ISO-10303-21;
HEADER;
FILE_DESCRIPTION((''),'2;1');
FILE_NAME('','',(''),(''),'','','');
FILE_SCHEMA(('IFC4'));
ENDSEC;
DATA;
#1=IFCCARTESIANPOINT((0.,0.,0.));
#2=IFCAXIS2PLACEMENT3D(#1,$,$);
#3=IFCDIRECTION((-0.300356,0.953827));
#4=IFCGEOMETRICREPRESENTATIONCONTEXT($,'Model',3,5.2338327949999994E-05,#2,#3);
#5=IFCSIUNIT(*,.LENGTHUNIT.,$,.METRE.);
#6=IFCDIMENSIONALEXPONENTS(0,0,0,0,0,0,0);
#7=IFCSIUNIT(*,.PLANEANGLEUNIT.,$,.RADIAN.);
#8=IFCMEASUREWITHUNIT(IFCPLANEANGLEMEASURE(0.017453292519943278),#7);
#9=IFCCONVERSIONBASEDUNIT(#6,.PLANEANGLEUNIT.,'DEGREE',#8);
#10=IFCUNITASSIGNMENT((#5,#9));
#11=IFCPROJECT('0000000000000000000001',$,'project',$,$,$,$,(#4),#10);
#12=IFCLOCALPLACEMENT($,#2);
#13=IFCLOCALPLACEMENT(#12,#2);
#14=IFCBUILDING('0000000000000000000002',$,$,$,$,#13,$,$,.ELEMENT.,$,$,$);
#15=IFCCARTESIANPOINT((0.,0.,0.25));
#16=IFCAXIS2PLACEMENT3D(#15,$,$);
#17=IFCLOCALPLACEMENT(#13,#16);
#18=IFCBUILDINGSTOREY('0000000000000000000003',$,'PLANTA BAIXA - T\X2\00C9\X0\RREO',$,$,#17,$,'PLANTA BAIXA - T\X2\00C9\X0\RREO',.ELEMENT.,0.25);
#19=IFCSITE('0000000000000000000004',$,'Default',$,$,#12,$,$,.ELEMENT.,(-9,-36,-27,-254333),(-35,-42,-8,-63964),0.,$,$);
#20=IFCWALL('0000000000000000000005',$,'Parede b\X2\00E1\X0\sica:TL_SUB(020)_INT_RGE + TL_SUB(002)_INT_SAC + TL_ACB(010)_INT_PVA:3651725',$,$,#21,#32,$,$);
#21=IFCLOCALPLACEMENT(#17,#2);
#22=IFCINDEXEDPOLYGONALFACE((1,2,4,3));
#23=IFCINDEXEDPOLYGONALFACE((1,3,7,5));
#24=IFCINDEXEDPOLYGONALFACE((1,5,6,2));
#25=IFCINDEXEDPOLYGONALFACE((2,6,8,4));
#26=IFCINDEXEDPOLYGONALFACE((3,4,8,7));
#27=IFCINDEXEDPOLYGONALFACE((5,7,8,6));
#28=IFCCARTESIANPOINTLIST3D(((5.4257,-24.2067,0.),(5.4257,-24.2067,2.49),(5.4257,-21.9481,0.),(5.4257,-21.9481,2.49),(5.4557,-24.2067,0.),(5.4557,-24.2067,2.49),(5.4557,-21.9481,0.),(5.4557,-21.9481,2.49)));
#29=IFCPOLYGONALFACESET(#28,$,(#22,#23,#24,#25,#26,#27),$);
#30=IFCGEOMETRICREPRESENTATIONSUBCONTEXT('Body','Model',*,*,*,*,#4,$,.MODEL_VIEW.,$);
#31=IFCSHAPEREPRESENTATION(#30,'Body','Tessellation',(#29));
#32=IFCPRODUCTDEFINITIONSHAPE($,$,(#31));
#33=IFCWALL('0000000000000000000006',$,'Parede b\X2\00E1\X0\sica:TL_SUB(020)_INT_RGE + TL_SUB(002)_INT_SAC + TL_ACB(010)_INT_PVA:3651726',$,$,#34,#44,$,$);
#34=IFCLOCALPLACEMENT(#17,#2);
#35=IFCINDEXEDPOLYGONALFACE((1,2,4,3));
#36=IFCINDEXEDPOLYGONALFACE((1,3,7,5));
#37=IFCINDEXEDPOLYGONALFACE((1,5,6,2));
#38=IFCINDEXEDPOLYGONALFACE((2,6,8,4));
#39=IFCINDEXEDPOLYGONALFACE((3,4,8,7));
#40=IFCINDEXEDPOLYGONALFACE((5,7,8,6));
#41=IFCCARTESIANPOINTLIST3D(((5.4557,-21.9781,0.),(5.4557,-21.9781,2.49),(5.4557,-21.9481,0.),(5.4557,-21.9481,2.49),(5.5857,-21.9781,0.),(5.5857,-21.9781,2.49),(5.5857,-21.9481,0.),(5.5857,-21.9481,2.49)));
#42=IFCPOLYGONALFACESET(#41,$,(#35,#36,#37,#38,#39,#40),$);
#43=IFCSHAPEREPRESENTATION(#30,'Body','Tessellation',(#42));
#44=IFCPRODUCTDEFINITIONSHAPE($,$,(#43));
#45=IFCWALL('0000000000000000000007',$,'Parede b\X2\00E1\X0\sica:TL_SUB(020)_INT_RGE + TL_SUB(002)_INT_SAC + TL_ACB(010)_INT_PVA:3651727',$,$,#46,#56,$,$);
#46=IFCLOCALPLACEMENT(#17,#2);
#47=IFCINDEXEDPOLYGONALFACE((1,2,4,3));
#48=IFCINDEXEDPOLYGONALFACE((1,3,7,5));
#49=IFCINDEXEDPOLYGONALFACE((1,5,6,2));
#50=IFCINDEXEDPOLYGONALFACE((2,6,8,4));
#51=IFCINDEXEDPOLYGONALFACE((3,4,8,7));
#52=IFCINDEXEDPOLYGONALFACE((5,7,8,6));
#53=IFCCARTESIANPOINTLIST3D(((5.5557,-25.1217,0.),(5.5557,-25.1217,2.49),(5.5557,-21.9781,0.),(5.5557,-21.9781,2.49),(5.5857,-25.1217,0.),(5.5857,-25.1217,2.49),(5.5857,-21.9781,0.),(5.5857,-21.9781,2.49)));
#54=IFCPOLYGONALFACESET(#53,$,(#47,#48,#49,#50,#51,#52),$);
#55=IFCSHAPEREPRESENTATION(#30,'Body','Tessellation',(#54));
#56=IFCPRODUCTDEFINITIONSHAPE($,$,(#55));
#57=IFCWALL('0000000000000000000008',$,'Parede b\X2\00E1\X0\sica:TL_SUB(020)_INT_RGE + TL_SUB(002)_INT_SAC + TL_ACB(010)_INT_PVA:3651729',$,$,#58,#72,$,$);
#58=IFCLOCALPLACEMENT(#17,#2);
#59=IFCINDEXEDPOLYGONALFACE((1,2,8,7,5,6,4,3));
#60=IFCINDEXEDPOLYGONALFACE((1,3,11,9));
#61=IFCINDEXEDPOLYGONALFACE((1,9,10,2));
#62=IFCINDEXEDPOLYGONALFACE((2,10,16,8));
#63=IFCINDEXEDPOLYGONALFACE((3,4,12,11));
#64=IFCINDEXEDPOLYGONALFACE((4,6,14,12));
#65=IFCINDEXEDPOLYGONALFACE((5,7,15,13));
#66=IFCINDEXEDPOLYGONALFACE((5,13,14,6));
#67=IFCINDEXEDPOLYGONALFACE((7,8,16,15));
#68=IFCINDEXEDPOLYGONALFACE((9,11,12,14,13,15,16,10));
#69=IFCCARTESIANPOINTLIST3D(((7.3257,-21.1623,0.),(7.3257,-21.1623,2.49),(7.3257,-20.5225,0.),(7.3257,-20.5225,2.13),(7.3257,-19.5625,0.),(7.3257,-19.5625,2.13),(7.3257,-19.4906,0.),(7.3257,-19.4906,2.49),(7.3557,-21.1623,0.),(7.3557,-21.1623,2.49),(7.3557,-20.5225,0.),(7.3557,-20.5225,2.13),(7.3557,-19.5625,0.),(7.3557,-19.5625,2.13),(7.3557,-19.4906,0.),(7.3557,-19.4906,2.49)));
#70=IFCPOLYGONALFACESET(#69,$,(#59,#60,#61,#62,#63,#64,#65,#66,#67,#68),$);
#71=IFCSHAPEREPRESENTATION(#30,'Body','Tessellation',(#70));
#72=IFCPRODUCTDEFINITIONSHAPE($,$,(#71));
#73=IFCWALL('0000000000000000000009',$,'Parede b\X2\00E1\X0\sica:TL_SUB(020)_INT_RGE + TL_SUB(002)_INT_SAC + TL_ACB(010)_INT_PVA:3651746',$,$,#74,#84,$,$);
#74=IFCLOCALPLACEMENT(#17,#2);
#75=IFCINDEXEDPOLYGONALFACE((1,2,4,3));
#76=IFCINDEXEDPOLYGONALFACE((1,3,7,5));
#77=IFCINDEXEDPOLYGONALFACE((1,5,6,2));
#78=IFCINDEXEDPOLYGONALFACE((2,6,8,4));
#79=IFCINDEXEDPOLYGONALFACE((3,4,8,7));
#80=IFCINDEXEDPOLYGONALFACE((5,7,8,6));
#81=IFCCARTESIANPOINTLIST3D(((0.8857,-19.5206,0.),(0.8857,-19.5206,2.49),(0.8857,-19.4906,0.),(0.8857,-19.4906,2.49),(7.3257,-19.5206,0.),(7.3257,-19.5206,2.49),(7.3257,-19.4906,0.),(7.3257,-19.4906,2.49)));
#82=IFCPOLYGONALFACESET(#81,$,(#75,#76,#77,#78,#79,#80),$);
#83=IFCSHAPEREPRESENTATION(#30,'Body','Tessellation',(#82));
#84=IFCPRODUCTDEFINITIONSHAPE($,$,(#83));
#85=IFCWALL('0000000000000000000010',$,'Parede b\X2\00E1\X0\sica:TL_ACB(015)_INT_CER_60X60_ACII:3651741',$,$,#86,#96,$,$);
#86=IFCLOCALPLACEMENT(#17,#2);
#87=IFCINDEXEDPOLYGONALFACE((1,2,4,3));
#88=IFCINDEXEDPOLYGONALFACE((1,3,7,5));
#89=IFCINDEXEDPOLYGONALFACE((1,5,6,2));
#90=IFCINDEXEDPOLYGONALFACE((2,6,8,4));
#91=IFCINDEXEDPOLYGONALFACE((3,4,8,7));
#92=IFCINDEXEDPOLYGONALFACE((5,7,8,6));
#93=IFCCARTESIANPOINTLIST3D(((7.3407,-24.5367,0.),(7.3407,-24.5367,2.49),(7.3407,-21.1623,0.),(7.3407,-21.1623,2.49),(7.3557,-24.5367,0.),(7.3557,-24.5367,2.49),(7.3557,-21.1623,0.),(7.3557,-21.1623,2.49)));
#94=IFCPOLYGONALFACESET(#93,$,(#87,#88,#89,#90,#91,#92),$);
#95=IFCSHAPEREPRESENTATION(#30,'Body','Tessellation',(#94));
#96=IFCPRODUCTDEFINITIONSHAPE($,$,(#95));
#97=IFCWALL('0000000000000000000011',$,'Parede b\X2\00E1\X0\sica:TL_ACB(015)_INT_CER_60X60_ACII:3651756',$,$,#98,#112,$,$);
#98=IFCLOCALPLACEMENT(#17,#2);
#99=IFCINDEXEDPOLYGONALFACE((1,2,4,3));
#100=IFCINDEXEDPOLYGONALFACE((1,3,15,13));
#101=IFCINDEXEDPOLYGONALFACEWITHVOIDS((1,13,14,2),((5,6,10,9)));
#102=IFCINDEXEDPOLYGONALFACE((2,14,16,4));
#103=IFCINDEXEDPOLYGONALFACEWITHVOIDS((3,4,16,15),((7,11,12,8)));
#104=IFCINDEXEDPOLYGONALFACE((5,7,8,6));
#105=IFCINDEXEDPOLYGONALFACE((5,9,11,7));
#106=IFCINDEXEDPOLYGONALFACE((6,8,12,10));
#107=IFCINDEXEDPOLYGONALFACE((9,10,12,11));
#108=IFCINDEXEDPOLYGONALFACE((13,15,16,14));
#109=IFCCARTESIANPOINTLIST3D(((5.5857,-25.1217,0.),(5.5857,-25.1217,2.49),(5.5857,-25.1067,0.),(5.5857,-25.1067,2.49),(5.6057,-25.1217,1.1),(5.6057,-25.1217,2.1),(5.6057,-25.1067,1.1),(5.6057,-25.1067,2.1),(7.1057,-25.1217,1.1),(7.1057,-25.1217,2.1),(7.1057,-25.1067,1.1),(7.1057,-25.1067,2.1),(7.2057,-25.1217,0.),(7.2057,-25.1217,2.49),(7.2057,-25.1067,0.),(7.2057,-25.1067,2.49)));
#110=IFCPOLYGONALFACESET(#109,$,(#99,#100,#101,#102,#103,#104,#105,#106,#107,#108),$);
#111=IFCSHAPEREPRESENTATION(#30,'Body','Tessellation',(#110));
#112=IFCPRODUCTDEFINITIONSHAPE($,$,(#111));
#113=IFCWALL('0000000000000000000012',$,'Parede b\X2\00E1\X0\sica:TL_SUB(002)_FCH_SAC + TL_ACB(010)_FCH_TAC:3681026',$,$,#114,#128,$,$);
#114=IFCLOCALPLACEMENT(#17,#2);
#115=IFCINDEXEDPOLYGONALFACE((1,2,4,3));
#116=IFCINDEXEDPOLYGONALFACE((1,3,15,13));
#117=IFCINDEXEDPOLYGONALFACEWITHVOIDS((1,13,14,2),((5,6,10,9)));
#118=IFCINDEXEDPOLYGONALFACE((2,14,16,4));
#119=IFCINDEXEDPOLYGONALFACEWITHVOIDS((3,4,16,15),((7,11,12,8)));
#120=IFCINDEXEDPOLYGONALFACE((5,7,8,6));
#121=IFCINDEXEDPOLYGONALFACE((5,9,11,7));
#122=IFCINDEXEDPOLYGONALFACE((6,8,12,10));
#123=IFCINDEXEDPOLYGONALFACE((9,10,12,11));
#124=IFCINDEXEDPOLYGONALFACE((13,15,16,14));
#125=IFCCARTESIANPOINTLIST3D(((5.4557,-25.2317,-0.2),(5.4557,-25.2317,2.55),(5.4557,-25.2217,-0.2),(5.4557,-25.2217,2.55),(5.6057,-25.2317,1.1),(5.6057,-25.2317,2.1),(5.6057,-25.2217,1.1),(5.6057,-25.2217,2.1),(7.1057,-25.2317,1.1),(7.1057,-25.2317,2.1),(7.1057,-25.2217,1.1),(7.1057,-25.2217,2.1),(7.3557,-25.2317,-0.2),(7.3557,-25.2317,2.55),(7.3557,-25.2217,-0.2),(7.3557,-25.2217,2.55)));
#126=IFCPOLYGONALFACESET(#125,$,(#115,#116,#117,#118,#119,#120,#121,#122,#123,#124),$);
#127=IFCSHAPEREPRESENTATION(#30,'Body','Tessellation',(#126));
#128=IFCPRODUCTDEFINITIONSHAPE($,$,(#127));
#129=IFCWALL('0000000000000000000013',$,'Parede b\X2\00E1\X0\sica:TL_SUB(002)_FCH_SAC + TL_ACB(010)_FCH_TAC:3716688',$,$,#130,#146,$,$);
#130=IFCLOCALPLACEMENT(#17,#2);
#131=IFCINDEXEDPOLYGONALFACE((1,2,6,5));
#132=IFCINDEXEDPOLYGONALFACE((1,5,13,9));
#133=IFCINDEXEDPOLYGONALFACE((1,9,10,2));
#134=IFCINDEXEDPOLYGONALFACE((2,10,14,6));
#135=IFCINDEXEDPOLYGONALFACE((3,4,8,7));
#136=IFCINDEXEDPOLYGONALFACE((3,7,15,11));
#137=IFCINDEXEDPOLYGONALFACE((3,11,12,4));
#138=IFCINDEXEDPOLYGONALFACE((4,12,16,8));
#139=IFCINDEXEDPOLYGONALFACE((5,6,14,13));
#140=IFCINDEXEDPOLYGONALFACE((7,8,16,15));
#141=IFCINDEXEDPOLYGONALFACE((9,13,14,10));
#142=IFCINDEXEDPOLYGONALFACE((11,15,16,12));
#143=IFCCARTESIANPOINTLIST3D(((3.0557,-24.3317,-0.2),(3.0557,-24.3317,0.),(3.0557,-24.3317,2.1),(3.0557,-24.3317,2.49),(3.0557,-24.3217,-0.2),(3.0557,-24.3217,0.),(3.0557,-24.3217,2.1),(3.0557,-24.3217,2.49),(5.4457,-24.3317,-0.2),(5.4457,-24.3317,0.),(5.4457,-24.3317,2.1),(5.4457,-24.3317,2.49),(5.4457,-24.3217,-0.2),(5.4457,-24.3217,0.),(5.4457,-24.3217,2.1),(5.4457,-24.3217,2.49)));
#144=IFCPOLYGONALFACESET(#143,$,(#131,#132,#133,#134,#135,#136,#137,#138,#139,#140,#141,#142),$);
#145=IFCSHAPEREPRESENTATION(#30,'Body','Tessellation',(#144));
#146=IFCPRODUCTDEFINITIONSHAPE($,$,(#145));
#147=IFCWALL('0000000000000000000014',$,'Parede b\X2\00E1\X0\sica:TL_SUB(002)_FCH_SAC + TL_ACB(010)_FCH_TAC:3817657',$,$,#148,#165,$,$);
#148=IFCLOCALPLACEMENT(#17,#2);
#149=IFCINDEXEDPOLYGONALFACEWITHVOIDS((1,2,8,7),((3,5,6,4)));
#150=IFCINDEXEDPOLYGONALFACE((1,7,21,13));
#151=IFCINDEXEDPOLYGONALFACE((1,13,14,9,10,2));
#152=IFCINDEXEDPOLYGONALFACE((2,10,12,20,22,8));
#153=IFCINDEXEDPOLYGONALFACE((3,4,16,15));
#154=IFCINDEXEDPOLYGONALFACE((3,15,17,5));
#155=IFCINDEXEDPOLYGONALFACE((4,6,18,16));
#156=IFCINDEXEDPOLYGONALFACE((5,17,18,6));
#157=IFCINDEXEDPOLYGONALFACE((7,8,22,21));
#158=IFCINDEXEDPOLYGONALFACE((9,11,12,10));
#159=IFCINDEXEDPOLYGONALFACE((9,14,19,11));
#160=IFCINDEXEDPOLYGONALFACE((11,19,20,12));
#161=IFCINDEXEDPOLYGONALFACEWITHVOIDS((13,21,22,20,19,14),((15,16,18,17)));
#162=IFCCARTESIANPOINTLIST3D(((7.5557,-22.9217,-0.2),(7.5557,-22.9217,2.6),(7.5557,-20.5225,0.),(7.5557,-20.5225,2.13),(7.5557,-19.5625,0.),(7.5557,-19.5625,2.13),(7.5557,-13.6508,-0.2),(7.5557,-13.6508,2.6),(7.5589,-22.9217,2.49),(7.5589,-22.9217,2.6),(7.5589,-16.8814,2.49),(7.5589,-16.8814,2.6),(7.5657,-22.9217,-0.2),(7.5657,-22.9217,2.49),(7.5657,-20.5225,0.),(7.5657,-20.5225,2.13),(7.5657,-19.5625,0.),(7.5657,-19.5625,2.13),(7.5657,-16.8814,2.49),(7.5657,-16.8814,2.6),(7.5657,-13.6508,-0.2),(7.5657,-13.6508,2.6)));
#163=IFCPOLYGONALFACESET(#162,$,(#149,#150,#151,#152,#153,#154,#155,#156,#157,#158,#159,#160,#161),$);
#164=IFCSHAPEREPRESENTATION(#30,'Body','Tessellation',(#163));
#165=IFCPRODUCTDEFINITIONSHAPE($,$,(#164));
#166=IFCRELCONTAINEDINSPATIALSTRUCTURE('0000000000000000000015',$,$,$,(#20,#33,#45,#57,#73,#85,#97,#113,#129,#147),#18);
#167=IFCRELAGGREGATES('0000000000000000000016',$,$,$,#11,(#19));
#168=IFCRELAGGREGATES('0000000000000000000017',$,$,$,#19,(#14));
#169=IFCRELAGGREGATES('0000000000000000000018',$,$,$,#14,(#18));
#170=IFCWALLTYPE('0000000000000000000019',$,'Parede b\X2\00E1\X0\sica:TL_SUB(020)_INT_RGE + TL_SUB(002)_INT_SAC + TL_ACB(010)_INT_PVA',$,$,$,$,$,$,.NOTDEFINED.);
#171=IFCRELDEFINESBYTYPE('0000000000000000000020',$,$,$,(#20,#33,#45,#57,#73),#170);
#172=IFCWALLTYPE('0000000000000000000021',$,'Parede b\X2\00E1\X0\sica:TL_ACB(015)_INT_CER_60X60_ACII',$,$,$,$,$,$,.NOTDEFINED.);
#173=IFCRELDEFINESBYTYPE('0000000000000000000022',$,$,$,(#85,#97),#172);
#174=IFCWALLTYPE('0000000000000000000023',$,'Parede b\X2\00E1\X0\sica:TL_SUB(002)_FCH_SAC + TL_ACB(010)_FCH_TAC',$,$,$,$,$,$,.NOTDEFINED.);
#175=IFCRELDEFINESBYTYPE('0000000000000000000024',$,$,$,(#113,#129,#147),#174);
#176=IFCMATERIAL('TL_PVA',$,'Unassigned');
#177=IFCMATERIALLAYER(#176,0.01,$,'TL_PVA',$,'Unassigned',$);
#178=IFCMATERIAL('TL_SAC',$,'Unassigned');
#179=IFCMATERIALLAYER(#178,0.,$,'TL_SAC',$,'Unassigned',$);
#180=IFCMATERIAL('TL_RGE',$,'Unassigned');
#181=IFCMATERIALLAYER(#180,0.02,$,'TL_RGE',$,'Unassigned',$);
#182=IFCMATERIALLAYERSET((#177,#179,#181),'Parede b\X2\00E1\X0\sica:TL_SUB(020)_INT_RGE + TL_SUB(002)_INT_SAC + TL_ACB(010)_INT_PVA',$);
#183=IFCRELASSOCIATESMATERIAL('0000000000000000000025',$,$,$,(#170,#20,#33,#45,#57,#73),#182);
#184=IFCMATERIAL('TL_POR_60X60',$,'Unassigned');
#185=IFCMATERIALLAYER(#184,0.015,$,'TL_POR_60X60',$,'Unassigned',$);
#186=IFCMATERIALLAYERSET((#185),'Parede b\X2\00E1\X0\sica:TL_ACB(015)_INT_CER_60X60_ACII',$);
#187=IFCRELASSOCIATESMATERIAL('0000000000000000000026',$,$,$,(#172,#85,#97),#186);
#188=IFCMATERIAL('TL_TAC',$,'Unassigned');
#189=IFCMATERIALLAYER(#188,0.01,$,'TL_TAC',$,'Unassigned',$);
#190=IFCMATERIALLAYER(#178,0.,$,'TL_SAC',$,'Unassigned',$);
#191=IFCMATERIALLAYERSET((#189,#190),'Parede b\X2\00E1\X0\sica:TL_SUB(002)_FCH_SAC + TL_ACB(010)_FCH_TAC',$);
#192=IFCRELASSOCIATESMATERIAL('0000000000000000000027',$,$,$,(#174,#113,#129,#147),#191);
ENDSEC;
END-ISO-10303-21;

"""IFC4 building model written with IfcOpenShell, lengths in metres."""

from ifc_helpers import new_model, entity, si_unit, converted_unit, direction, frame, frame_2d, origin, place, context, subcontext, project, spatial, polyline, rectangle, extrude, clip, bounded_halfspace, material, layer, layer_set, layer_usage, type_object, element, save


model = new_model("IFC4")

# Units and contexts
model_context = context("Model", 3, precision=5.2338327949999994e-05, world=origin(), true_north=direction((-0.300356, 0.953827)))
body_context = subcontext(model_context, "Body", "Model", "MODEL_VIEW")
ifc_project = project(units=[si_unit("LENGTHUNIT", "METRE"), converted_unit("PLANEANGLEUNIT", "DEGREE", entity("IfcPlaneAngleMeasure", 0.017453292519943278), si_unit("PLANEANGLEUNIT", "RADIAN"), dimensions=[0, 0, 0, 0, 0, 0, 0])], contexts=[model_context])

# Site, building, storey
site_placement = place(None, origin())
site = spatial("IfcSite", under=ifc_project, at=site_placement, Name="Default", CompositionType="ELEMENT", RefLatitude=(-9, -36, -27, -254333), RefLongitude=(-35, -42, -8, -63964), RefElevation=0.0)
building_placement = place(site_placement, origin())
building = spatial("IfcBuilding", under=site, at=building_placement, CompositionType="ELEMENT")
storey_placement = place(building_placement, frame((0.0, 0.0, 0.25)))
storey = spatial("IfcBuildingStorey", under=building, at=storey_placement, Name="PLANTA BAIXA - TÉRREO", LongName="PLANTA BAIXA - TÉRREO", CompositionType="ELEMENT", Elevation=0.25)

# Walls
ifc_material_1 = material(Name="TL_PVA", Category="Unassigned")
ifc_layer_1 = layer(ifc_material_1, 0.01, Name="TL_PVA", Category="Unassigned")
ifc_material_2 = material(Name="TL_SAC", Category="Unassigned")
ifc_layer_2 = layer(ifc_material_2, 0.0, Name="TL_SAC", Category="Unassigned")
ifc_material_3 = material(Name="TL_RGE", Category="Unassigned")
ifc_layer_3 = layer(ifc_material_3, 0.02, Name="TL_RGE", Category="Unassigned")
ifc_layer_set_1 = layer_set([ifc_layer_1, ifc_layer_2, ifc_layer_3], Name="Parede básica:TL_SUB(020)_INT_RGE + TL_SUB(002)_INT_SAC + TL_ACB(010)_INT_PVA")
wall_type_1 = type_object("IfcWallType", Name="Parede básica:TL_SUB(020)_INT_RGE + TL_SUB(002)_INT_SAC + TL_ACB(010)_INT_PVA", PredefinedType="NOTDEFINED", material=ifc_layer_set_1)
ifc_layer_usage_1 = layer_usage(ifc_layer_set_1, "AXIS2", "POSITIVE", -0.015)
wall_1_placement = place(storey_placement, frame((5.4407, -21.9481, 0.0), z_axis=(0.0, 0.0, 1.0), x_axis=(0.0, -1.0, 0.0)))
element("IfcWall", 1, at=wall_1_placement, inside=storey, type_object=wall_type_1, material=ifc_layer_usage_1, Name="Parede básica:TL_SUB(020)_INT_RGE + TL_SUB(002)_INT_SAC + TL_ACB(010)_INT_PVA:3651725", context=body_context, shape_type="SweptSolid", body=[
    extrude(rectangle(XDim=2.2587, YDim=0.03, at=frame_2d((1.1293, 0.0), x_axis=(-1.0, 0.0))), origin(), (0.0, 0.0, 1.0), 2.49),
])
ifc_layer_usage_2 = layer_usage(ifc_layer_set_1, "AXIS2", "POSITIVE", -0.015)
wall_2_placement = place(storey_placement, frame((5.5857, -21.9631, 0.0), z_axis=(0.0, 0.0, 1.0), x_axis=(-1.0, 0.0, 0.0)))
element("IfcWall", 2, at=wall_2_placement, inside=storey, type_object=wall_type_1, material=ifc_layer_usage_2, Name="Parede básica:TL_SUB(020)_INT_RGE + TL_SUB(002)_INT_SAC + TL_ACB(010)_INT_PVA:3651726", context=body_context, shape_type="SweptSolid", body=[
    extrude(rectangle(XDim=0.13, YDim=0.03, at=frame_2d((0.065, 0.0), x_axis=(-1.0, 0.0))), origin(), (0.0, 0.0, 1.0), 2.49),
])
ifc_layer_usage_3 = layer_usage(ifc_layer_set_1, "AXIS2", "POSITIVE", -0.015)
wall_3_placement = place(storey_placement, frame((5.5707, -25.1217, 0.0), z_axis=(0.0, 0.0, 1.0), x_axis=(0.0, 1.0, 0.0)))
element("IfcWall", 3, at=wall_3_placement, inside=storey, type_object=wall_type_1, material=ifc_layer_usage_3, Name="Parede básica:TL_SUB(020)_INT_RGE + TL_SUB(002)_INT_SAC + TL_ACB(010)_INT_PVA:3651727", context=body_context, shape_type="SweptSolid", body=[
    extrude(rectangle(XDim=3.1437, YDim=0.03, at=frame_2d((1.5718, 0.0), x_axis=(-1.0, 0.0))), origin(), (0.0, 0.0, 1.0), 2.49),
])

# Wall, opening
ifc_layer_usage_4 = layer_usage(ifc_layer_set_1, "AXIS2", "POSITIVE", -0.015)
wall_4_placement = place(storey_placement, frame((7.3407, -19.4906, 0.0), z_axis=(0.0, 0.0, 1.0), x_axis=(0.0, -1.0, 0.0)))
wall_4 = element("IfcWall", 4, at=wall_4_placement, inside=storey, type_object=wall_type_1, material=ifc_layer_usage_4, Name="Parede básica:TL_SUB(020)_INT_RGE + TL_SUB(002)_INT_SAC + TL_ACB(010)_INT_PVA:3651729", context=body_context, shape_type="SweptSolid", body=[
    extrude(rectangle(XDim=1.6717, YDim=0.03, at=frame_2d((0.8359, 0.0), x_axis=(-1.0, 0.0))), origin(), (0.0, 0.0, 1.0), 2.49),
])
opening_1_placement = place(wall_4_placement, frame((-19.4906, -7.3407, 0.0)))
element("IfcOpeningElement", 5, at=opening_1_placement, cuts=wall_4, PredefinedType="OPENING", context=body_context, shape_type="SweptSolid", body=[
    extrude(rectangle(XDim=2.13, YDim=0.96, at=frame_2d((0.0, 0.0), x_axis=(0.0, 1.0))), frame((20.0425, 5.8317, 1.065), z_axis=(0.0, 1.0, 0.0), x_axis=(-1.0, 0.0, 0.0)), (0.0, 0.0, 1.0), 3.048),
])

# Walls
ifc_layer_usage_5 = layer_usage(ifc_layer_set_1, "AXIS2", "NEGATIVE", 0.015)
wall_5_placement = place(storey_placement, frame((7.3257, -19.5056, 0.0), z_axis=(0.0, 0.0, 1.0), x_axis=(-1.0, 0.0, 0.0)))
element("IfcWall", 6, at=wall_5_placement, inside=storey, type_object=wall_type_1, material=ifc_layer_usage_5, Name="Parede básica:TL_SUB(020)_INT_RGE + TL_SUB(002)_INT_SAC + TL_ACB(010)_INT_PVA:3651746", context=body_context, shape_type="SweptSolid", body=[
    extrude(rectangle(XDim=6.44, YDim=0.03, at=frame_2d((3.22, 0.0), x_axis=(-1.0, 0.0))), origin(), (0.0, 0.0, 1.0), 2.49),
])
ifc_material_4 = material(Name="TL_POR_60X60", Category="Unassigned")
ifc_layer_4 = layer(ifc_material_4, 0.015, Name="TL_POR_60X60", Category="Unassigned")
ifc_layer_set_2 = layer_set([ifc_layer_4], Name="Parede básica:TL_ACB(015)_INT_CER_60X60_ACII")
ifc_layer_usage_6 = layer_usage(ifc_layer_set_2, "AXIS2", "POSITIVE", -0.0075)
wall_type_2 = type_object("IfcWallType", Name="Parede básica:TL_ACB(015)_INT_CER_60X60_ACII", PredefinedType="NOTDEFINED", material=ifc_layer_set_2)
wall_6_placement = place(storey_placement, frame((7.3482, -21.1623, 0.0), z_axis=(0.0, 0.0, 1.0), x_axis=(0.0, -1.0, 0.0)))
element("IfcWall", 7, at=wall_6_placement, inside=storey, type_object=wall_type_2, material=ifc_layer_usage_6, Name="Parede básica:TL_ACB(015)_INT_CER_60X60_ACII:3651741", context=body_context, shape_type="SweptSolid", body=[
    extrude(rectangle(XDim=3.3744, YDim=0.015, at=frame_2d((1.6872, 0.0), x_axis=(-1.0, 0.0))), origin(), (0.0, 0.0, 1.0), 2.49),
])

# Walls, openings
ifc_layer_usage_7 = layer_usage(ifc_layer_set_2, "AXIS2", "POSITIVE", -0.0075)
wall_7_placement = place(storey_placement, frame((7.2057, -25.1142, 0.0), z_axis=(0.0, 0.0, 1.0), x_axis=(-1.0, 0.0, 0.0)))
wall_7 = element("IfcWall", 8, at=wall_7_placement, inside=storey, type_object=wall_type_2, material=ifc_layer_usage_7, Name="Parede básica:TL_ACB(015)_INT_CER_60X60_ACII:3651756", context=body_context, shape_type="SweptSolid", body=[
    extrude(rectangle(XDim=1.62, YDim=0.015, at=frame_2d((0.81, 0.0), x_axis=(-1.0, 0.0))), origin(), (0.0, 0.0, 1.0), 2.49),
])
opening_2_placement = place(wall_7_placement, frame((7.2057, -25.1142, 1.1)))
element("IfcOpeningElement", 9, at=opening_2_placement, cuts=wall_7, PredefinedType="OPENING", context=body_context, shape_type="SweptSolid", body=[
    extrude(rectangle(XDim=1.0, YDim=1.5, at=frame_2d((0.0, 0.0), x_axis=(0.0, 1.0))), frame((-6.3557, 23.5977, 0.5), z_axis=(0.0, 1.0, 0.0), x_axis=(1.0, 0.0, 0.0)), (0.0, 0.0, 1.0), 3.048),
])
ifc_material_5 = material(Name="TL_TAC", Category="Unassigned")
ifc_layer_5 = layer(ifc_material_5, 0.01, Name="TL_TAC", Category="Unassigned")
ifc_layer_6 = layer(ifc_material_2, 0.0, Name="TL_SAC", Category="Unassigned")
ifc_layer_set_3 = layer_set([ifc_layer_5, ifc_layer_6], Name="Parede básica:TL_SUB(002)_FCH_SAC + TL_ACB(010)_FCH_TAC")
ifc_layer_usage_8 = layer_usage(ifc_layer_set_3, "AXIS2", "POSITIVE", -0.005)
wall_type_3 = type_object("IfcWallType", Name="Parede básica:TL_SUB(002)_FCH_SAC + TL_ACB(010)_FCH_TAC", PredefinedType="NOTDEFINED", material=ifc_layer_set_3)
wall_8_placement = place(storey_placement, frame((7.3557, -25.2267, -0.2), z_axis=(0.0, 0.0, 1.0), x_axis=(-1.0, 0.0, 0.0)))
wall_8 = element("IfcWall", 10, at=wall_8_placement, inside=storey, type_object=wall_type_3, material=ifc_layer_usage_8, Name="Parede básica:TL_SUB(002)_FCH_SAC + TL_ACB(010)_FCH_TAC:3681026", context=body_context, shape_type="SweptSolid", body=[
    extrude(rectangle(XDim=1.9, YDim=0.01, at=frame_2d((0.95, 0.0), x_axis=(-1.0, 0.0))), origin(), (0.0, 0.0, 1.0), 2.75),
])
opening_3_placement = place(wall_8_placement, frame((7.3557, -25.2267, 1.3)))
element("IfcOpeningElement", 11, at=opening_3_placement, cuts=wall_8, PredefinedType="OPENING", context=body_context, shape_type="SweptSolid", body=[
    extrude(rectangle(XDim=1.0, YDim=1.5, at=frame_2d((0.0, 0.0), x_axis=(0.0, 1.0))), frame((-6.3557, 23.5977, 0.5), z_axis=(0.0, 1.0, 0.0), x_axis=(1.0, 0.0, 0.0)), (0.0, 0.0, 1.0), 3.048),
])
ifc_layer_usage_9 = layer_usage(ifc_layer_set_3, "AXIS2", "NEGATIVE", 0.005)
wall_9_placement = place(storey_placement, frame((5.4457, -24.3267, -0.2), z_axis=(0.0, 0.0, 1.0), x_axis=(-1.0, 0.0, 0.0)))
wall_9 = element("IfcWall", 12, at=wall_9_placement, inside=storey, type_object=wall_type_3, material=ifc_layer_usage_9, Name="Parede básica:TL_SUB(002)_FCH_SAC + TL_ACB(010)_FCH_TAC:3716688", context=body_context, shape_type="SweptSolid", body=[
    extrude(rectangle(XDim=2.39, YDim=0.01, at=frame_2d((1.195, 0.0), x_axis=(-1.0, 0.0))), origin(), (0.0, 0.0, 1.0), 2.69),
])
opening_4_placement = place(wall_9_placement, frame((5.4457, -24.3267, 0.2)))
element("IfcOpeningElement", 13, at=opening_4_placement, cuts=wall_9, PredefinedType="OPENING", context=body_context, shape_type="SweptSolid", body=[
    extrude(rectangle(XDim=2.1, YDim=2.4, at=frame_2d((0.0, 0.0), x_axis=(0.0, 1.0))), frame((-4.2557, 22.7977, 1.05), z_axis=(0.0, 1.0, 0.0), x_axis=(-1.0, 0.0, 0.0)), (0.0, 0.0, 1.0), 3.048),
])
ifc_layer_usage_10 = layer_usage(ifc_layer_set_3, "AXIS2", "NEGATIVE", 0.005)
wall_10_placement = place(storey_placement, frame((7.5607, -22.9217, -0.2), z_axis=(0.0, 0.0, 1.0), x_axis=(0.0, 1.0, 0.0)))
wall_10 = element("IfcWall", 14, at=wall_10_placement, inside=storey, type_object=wall_type_3, material=ifc_layer_usage_10, Name="Parede básica:TL_SUB(002)_FCH_SAC + TL_ACB(010)_FCH_TAC:3817657", context=body_context, shape_type="Clipping", body=[
    clip(extrude(rectangle(XDim=9.2709, YDim=0.01, at=frame_2d((4.6355, 0.0), x_axis=(-1.0, 0.0))), origin(), (0.0, 0.0, 1.0), 2.8), bounded_halfspace(frame((0.0, -0.005, 2.69), z_axis=(0.0, 0.0, -1.0), x_axis=(-1.0, 0.0, 0.0)), True, frame((0.0, -0.005, 2.69)), polyline([(0.0, 0.0), (0.01, 0.0), (6.0403, 0.0), (6.0403, 0.0068), (0.0, 0.0068), (0.0, 0.0)]))),
])
opening_5_placement = place(wall_10_placement, frame((22.9217, 7.5607, 0.2)))
element("IfcOpeningElement", 15, at=opening_5_placement, cuts=wall_10, PredefinedType="OPENING", context=body_context, shape_type="SweptSolid", body=[
    extrude(rectangle(XDim=2.13, YDim=0.96, at=frame_2d((0.0, 0.0), x_axis=(1.0, 0.0))), frame((-20.0425, -8.8797, 1.065), z_axis=(0.0, 1.0, 0.0), x_axis=(0.0, 0.0, 1.0)), (0.0, 0.0, 1.0), 3.048),
])

save(model, "model.ifc")
